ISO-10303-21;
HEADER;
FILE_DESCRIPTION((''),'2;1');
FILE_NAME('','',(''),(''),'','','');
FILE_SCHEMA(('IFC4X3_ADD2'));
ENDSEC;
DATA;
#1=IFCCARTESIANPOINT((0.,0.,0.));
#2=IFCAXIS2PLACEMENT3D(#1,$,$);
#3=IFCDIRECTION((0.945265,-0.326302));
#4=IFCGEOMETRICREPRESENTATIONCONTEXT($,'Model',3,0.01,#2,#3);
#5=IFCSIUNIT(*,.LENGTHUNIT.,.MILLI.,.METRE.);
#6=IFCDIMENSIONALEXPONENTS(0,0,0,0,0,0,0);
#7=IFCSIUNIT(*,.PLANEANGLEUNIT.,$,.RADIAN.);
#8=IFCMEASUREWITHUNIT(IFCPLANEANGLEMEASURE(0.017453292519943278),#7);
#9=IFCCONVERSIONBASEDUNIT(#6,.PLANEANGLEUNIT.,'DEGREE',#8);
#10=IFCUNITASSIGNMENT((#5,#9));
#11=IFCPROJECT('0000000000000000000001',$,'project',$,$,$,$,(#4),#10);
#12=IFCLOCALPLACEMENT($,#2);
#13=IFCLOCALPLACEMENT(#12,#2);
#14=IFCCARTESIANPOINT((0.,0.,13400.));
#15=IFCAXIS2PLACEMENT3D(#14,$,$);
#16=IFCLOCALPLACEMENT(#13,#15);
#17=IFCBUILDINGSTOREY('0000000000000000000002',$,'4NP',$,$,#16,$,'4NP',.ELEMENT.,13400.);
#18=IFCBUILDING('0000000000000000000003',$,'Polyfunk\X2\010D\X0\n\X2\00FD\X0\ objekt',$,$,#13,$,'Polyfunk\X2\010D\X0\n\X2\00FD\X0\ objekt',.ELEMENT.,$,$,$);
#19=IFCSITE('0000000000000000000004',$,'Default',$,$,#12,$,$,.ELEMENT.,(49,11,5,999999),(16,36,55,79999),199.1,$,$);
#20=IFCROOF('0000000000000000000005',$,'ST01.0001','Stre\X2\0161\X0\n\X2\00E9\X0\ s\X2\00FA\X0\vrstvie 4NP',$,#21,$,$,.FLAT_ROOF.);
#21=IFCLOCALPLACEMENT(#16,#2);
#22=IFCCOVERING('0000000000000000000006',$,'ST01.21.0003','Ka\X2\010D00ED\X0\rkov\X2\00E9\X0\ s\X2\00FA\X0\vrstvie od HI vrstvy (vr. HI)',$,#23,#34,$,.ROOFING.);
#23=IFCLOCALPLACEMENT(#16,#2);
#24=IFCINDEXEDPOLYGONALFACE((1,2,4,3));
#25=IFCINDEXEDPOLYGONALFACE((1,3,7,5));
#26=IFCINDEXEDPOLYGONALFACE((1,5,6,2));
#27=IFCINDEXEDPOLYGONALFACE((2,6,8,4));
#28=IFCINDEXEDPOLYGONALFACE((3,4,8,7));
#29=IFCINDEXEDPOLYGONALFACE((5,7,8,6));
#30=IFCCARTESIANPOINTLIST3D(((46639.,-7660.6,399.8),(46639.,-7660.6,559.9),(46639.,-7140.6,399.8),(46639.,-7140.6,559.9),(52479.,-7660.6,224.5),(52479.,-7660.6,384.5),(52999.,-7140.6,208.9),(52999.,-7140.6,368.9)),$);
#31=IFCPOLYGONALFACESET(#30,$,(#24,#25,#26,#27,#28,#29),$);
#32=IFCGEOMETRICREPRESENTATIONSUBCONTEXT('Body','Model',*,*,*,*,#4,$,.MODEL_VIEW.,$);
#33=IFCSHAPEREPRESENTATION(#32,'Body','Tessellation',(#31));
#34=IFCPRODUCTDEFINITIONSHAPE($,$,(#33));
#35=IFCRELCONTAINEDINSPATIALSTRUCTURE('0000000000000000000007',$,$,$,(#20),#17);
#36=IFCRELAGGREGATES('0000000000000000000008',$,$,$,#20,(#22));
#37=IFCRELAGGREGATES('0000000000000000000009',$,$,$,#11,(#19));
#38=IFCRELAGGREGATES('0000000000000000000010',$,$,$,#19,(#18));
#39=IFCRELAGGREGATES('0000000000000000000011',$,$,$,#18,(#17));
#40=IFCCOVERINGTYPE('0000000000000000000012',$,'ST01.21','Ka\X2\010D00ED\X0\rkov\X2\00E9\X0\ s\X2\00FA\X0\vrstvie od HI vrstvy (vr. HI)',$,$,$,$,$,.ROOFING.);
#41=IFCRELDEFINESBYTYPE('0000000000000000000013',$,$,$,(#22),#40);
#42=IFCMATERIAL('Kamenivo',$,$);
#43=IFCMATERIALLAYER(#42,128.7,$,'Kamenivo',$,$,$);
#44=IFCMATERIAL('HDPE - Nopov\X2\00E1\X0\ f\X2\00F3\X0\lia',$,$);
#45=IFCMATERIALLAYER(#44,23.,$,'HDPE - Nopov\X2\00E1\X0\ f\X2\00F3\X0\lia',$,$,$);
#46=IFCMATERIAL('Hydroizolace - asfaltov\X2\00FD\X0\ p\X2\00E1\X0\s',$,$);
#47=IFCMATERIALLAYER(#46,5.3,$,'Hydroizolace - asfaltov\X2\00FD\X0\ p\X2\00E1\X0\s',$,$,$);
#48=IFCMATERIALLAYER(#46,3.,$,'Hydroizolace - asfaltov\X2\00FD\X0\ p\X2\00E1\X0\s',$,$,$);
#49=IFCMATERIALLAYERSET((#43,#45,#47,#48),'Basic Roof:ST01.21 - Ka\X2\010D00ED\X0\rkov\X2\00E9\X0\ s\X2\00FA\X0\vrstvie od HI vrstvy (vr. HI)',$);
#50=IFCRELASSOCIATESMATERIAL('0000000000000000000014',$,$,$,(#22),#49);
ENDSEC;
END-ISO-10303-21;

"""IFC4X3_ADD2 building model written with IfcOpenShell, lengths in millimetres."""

from ifc_helpers import new_model, entity, si_unit, converted_unit, direction, frame, origin, place, context, subcontext, project, spatial, polyline, outline, extrude, material, layer, layer_set, type_object, element, aggregate, save


model = new_model("IFC4X3_ADD2")

# Units and contexts
model_context = context("Model", 3, precision=0.01, world=origin(), true_north=direction((0.945265, -0.326302)))
body_context = subcontext(model_context, "Body", "Model", "MODEL_VIEW")
ifc_project = project(units=[si_unit("LENGTHUNIT", "METRE", prefix="MILLI"), converted_unit("PLANEANGLEUNIT", "DEGREE", entity("IfcPlaneAngleMeasure", 0.017453292519943278), si_unit("PLANEANGLEUNIT", "RADIAN"), dimensions=[0, 0, 0, 0, 0, 0, 0])], contexts=[model_context])

# Site, building, storey
site_placement = place(None, origin())
site = spatial("IfcSite", under=ifc_project, at=site_placement, Name="Default", CompositionType="ELEMENT", RefLatitude=(49, 11, 5, 999999), RefLongitude=(16, 36, 55, 79999), RefElevation=199.1)
building_placement = place(site_placement, origin())
building = spatial("IfcBuilding", under=site, at=building_placement, Name="Polyfunkčný objekt", LongName="Polyfunkčný objekt", CompositionType="ELEMENT")
storey_placement = place(building_placement, frame((0.0, 0.0, 13400.0)))
storey = spatial("IfcBuildingStorey", under=building, at=storey_placement, Name="4NP", LongName="4NP", CompositionType="ELEMENT", Elevation=13400.0)

# Roof, covering
roof = element("IfcRoof", 1, inside=storey, Name="ST01.0001", Description="Strešné súvrstvie 4NP", PredefinedType="FLAT_ROOF")
ifc_material_1 = material(Name="Kamenivo")
ifc_layer_1 = layer(ifc_material_1, 128.7, Name="Kamenivo")
ifc_material_2 = material(Name="HDPE - Nopová fólia")
ifc_layer_2 = layer(ifc_material_2, 23.0, Name="HDPE - Nopová fólia")
ifc_material_3 = material(Name="Hydroizolace - asfaltový pás")
ifc_layer_3 = layer(ifc_material_3, 5.3, Name="Hydroizolace - asfaltový pás")
ifc_layer_4 = layer(ifc_material_3, 3.0, Name="Hydroizolace - asfaltový pás")
ifc_layer_set_1 = layer_set([ifc_layer_1, ifc_layer_2, ifc_layer_3, ifc_layer_4], Name="Basic Roof:ST01.21 - Kačírkové súvrstvie od HI vrstvy (vr. HI)")
covering_type = type_object("IfcCoveringType", Name="ST01.21", Description="Kačírkové súvrstvie od HI vrstvy (vr. HI)", PredefinedType="ROOFING")
placement_1 = place(storey_placement, frame((46639.0, -7660.6, 208.9)))
covering_1_placement = place(placement_1, origin())
covering_1 = element("IfcCovering", 2, at=covering_1_placement, type_object=covering_type, material=ifc_layer_set_1, Name="ST01.21.0003", Description="Kačírkové súvrstvie od HI vrstvy (vr. HI)", PredefinedType="ROOFING", context=body_context, shape_type="SweptSolid", body=[
    extrude(outline(polyline([(3181.4, 260.0), (-3181.4, 260.0), (-3181.4, -260.0), (2661.2, -260.0), (3181.4, 260.0)])), frame((3180.0, 260.0, 95.5), z_axis=(0.030015, 0.0, 0.999549), x_axis=(0.999549, 0.0, -0.030015)), (-0.030015, 0.0, 0.999549), 160.1),
])
aggregate(roof, [covering_1])

save(model, "model.ifc")
